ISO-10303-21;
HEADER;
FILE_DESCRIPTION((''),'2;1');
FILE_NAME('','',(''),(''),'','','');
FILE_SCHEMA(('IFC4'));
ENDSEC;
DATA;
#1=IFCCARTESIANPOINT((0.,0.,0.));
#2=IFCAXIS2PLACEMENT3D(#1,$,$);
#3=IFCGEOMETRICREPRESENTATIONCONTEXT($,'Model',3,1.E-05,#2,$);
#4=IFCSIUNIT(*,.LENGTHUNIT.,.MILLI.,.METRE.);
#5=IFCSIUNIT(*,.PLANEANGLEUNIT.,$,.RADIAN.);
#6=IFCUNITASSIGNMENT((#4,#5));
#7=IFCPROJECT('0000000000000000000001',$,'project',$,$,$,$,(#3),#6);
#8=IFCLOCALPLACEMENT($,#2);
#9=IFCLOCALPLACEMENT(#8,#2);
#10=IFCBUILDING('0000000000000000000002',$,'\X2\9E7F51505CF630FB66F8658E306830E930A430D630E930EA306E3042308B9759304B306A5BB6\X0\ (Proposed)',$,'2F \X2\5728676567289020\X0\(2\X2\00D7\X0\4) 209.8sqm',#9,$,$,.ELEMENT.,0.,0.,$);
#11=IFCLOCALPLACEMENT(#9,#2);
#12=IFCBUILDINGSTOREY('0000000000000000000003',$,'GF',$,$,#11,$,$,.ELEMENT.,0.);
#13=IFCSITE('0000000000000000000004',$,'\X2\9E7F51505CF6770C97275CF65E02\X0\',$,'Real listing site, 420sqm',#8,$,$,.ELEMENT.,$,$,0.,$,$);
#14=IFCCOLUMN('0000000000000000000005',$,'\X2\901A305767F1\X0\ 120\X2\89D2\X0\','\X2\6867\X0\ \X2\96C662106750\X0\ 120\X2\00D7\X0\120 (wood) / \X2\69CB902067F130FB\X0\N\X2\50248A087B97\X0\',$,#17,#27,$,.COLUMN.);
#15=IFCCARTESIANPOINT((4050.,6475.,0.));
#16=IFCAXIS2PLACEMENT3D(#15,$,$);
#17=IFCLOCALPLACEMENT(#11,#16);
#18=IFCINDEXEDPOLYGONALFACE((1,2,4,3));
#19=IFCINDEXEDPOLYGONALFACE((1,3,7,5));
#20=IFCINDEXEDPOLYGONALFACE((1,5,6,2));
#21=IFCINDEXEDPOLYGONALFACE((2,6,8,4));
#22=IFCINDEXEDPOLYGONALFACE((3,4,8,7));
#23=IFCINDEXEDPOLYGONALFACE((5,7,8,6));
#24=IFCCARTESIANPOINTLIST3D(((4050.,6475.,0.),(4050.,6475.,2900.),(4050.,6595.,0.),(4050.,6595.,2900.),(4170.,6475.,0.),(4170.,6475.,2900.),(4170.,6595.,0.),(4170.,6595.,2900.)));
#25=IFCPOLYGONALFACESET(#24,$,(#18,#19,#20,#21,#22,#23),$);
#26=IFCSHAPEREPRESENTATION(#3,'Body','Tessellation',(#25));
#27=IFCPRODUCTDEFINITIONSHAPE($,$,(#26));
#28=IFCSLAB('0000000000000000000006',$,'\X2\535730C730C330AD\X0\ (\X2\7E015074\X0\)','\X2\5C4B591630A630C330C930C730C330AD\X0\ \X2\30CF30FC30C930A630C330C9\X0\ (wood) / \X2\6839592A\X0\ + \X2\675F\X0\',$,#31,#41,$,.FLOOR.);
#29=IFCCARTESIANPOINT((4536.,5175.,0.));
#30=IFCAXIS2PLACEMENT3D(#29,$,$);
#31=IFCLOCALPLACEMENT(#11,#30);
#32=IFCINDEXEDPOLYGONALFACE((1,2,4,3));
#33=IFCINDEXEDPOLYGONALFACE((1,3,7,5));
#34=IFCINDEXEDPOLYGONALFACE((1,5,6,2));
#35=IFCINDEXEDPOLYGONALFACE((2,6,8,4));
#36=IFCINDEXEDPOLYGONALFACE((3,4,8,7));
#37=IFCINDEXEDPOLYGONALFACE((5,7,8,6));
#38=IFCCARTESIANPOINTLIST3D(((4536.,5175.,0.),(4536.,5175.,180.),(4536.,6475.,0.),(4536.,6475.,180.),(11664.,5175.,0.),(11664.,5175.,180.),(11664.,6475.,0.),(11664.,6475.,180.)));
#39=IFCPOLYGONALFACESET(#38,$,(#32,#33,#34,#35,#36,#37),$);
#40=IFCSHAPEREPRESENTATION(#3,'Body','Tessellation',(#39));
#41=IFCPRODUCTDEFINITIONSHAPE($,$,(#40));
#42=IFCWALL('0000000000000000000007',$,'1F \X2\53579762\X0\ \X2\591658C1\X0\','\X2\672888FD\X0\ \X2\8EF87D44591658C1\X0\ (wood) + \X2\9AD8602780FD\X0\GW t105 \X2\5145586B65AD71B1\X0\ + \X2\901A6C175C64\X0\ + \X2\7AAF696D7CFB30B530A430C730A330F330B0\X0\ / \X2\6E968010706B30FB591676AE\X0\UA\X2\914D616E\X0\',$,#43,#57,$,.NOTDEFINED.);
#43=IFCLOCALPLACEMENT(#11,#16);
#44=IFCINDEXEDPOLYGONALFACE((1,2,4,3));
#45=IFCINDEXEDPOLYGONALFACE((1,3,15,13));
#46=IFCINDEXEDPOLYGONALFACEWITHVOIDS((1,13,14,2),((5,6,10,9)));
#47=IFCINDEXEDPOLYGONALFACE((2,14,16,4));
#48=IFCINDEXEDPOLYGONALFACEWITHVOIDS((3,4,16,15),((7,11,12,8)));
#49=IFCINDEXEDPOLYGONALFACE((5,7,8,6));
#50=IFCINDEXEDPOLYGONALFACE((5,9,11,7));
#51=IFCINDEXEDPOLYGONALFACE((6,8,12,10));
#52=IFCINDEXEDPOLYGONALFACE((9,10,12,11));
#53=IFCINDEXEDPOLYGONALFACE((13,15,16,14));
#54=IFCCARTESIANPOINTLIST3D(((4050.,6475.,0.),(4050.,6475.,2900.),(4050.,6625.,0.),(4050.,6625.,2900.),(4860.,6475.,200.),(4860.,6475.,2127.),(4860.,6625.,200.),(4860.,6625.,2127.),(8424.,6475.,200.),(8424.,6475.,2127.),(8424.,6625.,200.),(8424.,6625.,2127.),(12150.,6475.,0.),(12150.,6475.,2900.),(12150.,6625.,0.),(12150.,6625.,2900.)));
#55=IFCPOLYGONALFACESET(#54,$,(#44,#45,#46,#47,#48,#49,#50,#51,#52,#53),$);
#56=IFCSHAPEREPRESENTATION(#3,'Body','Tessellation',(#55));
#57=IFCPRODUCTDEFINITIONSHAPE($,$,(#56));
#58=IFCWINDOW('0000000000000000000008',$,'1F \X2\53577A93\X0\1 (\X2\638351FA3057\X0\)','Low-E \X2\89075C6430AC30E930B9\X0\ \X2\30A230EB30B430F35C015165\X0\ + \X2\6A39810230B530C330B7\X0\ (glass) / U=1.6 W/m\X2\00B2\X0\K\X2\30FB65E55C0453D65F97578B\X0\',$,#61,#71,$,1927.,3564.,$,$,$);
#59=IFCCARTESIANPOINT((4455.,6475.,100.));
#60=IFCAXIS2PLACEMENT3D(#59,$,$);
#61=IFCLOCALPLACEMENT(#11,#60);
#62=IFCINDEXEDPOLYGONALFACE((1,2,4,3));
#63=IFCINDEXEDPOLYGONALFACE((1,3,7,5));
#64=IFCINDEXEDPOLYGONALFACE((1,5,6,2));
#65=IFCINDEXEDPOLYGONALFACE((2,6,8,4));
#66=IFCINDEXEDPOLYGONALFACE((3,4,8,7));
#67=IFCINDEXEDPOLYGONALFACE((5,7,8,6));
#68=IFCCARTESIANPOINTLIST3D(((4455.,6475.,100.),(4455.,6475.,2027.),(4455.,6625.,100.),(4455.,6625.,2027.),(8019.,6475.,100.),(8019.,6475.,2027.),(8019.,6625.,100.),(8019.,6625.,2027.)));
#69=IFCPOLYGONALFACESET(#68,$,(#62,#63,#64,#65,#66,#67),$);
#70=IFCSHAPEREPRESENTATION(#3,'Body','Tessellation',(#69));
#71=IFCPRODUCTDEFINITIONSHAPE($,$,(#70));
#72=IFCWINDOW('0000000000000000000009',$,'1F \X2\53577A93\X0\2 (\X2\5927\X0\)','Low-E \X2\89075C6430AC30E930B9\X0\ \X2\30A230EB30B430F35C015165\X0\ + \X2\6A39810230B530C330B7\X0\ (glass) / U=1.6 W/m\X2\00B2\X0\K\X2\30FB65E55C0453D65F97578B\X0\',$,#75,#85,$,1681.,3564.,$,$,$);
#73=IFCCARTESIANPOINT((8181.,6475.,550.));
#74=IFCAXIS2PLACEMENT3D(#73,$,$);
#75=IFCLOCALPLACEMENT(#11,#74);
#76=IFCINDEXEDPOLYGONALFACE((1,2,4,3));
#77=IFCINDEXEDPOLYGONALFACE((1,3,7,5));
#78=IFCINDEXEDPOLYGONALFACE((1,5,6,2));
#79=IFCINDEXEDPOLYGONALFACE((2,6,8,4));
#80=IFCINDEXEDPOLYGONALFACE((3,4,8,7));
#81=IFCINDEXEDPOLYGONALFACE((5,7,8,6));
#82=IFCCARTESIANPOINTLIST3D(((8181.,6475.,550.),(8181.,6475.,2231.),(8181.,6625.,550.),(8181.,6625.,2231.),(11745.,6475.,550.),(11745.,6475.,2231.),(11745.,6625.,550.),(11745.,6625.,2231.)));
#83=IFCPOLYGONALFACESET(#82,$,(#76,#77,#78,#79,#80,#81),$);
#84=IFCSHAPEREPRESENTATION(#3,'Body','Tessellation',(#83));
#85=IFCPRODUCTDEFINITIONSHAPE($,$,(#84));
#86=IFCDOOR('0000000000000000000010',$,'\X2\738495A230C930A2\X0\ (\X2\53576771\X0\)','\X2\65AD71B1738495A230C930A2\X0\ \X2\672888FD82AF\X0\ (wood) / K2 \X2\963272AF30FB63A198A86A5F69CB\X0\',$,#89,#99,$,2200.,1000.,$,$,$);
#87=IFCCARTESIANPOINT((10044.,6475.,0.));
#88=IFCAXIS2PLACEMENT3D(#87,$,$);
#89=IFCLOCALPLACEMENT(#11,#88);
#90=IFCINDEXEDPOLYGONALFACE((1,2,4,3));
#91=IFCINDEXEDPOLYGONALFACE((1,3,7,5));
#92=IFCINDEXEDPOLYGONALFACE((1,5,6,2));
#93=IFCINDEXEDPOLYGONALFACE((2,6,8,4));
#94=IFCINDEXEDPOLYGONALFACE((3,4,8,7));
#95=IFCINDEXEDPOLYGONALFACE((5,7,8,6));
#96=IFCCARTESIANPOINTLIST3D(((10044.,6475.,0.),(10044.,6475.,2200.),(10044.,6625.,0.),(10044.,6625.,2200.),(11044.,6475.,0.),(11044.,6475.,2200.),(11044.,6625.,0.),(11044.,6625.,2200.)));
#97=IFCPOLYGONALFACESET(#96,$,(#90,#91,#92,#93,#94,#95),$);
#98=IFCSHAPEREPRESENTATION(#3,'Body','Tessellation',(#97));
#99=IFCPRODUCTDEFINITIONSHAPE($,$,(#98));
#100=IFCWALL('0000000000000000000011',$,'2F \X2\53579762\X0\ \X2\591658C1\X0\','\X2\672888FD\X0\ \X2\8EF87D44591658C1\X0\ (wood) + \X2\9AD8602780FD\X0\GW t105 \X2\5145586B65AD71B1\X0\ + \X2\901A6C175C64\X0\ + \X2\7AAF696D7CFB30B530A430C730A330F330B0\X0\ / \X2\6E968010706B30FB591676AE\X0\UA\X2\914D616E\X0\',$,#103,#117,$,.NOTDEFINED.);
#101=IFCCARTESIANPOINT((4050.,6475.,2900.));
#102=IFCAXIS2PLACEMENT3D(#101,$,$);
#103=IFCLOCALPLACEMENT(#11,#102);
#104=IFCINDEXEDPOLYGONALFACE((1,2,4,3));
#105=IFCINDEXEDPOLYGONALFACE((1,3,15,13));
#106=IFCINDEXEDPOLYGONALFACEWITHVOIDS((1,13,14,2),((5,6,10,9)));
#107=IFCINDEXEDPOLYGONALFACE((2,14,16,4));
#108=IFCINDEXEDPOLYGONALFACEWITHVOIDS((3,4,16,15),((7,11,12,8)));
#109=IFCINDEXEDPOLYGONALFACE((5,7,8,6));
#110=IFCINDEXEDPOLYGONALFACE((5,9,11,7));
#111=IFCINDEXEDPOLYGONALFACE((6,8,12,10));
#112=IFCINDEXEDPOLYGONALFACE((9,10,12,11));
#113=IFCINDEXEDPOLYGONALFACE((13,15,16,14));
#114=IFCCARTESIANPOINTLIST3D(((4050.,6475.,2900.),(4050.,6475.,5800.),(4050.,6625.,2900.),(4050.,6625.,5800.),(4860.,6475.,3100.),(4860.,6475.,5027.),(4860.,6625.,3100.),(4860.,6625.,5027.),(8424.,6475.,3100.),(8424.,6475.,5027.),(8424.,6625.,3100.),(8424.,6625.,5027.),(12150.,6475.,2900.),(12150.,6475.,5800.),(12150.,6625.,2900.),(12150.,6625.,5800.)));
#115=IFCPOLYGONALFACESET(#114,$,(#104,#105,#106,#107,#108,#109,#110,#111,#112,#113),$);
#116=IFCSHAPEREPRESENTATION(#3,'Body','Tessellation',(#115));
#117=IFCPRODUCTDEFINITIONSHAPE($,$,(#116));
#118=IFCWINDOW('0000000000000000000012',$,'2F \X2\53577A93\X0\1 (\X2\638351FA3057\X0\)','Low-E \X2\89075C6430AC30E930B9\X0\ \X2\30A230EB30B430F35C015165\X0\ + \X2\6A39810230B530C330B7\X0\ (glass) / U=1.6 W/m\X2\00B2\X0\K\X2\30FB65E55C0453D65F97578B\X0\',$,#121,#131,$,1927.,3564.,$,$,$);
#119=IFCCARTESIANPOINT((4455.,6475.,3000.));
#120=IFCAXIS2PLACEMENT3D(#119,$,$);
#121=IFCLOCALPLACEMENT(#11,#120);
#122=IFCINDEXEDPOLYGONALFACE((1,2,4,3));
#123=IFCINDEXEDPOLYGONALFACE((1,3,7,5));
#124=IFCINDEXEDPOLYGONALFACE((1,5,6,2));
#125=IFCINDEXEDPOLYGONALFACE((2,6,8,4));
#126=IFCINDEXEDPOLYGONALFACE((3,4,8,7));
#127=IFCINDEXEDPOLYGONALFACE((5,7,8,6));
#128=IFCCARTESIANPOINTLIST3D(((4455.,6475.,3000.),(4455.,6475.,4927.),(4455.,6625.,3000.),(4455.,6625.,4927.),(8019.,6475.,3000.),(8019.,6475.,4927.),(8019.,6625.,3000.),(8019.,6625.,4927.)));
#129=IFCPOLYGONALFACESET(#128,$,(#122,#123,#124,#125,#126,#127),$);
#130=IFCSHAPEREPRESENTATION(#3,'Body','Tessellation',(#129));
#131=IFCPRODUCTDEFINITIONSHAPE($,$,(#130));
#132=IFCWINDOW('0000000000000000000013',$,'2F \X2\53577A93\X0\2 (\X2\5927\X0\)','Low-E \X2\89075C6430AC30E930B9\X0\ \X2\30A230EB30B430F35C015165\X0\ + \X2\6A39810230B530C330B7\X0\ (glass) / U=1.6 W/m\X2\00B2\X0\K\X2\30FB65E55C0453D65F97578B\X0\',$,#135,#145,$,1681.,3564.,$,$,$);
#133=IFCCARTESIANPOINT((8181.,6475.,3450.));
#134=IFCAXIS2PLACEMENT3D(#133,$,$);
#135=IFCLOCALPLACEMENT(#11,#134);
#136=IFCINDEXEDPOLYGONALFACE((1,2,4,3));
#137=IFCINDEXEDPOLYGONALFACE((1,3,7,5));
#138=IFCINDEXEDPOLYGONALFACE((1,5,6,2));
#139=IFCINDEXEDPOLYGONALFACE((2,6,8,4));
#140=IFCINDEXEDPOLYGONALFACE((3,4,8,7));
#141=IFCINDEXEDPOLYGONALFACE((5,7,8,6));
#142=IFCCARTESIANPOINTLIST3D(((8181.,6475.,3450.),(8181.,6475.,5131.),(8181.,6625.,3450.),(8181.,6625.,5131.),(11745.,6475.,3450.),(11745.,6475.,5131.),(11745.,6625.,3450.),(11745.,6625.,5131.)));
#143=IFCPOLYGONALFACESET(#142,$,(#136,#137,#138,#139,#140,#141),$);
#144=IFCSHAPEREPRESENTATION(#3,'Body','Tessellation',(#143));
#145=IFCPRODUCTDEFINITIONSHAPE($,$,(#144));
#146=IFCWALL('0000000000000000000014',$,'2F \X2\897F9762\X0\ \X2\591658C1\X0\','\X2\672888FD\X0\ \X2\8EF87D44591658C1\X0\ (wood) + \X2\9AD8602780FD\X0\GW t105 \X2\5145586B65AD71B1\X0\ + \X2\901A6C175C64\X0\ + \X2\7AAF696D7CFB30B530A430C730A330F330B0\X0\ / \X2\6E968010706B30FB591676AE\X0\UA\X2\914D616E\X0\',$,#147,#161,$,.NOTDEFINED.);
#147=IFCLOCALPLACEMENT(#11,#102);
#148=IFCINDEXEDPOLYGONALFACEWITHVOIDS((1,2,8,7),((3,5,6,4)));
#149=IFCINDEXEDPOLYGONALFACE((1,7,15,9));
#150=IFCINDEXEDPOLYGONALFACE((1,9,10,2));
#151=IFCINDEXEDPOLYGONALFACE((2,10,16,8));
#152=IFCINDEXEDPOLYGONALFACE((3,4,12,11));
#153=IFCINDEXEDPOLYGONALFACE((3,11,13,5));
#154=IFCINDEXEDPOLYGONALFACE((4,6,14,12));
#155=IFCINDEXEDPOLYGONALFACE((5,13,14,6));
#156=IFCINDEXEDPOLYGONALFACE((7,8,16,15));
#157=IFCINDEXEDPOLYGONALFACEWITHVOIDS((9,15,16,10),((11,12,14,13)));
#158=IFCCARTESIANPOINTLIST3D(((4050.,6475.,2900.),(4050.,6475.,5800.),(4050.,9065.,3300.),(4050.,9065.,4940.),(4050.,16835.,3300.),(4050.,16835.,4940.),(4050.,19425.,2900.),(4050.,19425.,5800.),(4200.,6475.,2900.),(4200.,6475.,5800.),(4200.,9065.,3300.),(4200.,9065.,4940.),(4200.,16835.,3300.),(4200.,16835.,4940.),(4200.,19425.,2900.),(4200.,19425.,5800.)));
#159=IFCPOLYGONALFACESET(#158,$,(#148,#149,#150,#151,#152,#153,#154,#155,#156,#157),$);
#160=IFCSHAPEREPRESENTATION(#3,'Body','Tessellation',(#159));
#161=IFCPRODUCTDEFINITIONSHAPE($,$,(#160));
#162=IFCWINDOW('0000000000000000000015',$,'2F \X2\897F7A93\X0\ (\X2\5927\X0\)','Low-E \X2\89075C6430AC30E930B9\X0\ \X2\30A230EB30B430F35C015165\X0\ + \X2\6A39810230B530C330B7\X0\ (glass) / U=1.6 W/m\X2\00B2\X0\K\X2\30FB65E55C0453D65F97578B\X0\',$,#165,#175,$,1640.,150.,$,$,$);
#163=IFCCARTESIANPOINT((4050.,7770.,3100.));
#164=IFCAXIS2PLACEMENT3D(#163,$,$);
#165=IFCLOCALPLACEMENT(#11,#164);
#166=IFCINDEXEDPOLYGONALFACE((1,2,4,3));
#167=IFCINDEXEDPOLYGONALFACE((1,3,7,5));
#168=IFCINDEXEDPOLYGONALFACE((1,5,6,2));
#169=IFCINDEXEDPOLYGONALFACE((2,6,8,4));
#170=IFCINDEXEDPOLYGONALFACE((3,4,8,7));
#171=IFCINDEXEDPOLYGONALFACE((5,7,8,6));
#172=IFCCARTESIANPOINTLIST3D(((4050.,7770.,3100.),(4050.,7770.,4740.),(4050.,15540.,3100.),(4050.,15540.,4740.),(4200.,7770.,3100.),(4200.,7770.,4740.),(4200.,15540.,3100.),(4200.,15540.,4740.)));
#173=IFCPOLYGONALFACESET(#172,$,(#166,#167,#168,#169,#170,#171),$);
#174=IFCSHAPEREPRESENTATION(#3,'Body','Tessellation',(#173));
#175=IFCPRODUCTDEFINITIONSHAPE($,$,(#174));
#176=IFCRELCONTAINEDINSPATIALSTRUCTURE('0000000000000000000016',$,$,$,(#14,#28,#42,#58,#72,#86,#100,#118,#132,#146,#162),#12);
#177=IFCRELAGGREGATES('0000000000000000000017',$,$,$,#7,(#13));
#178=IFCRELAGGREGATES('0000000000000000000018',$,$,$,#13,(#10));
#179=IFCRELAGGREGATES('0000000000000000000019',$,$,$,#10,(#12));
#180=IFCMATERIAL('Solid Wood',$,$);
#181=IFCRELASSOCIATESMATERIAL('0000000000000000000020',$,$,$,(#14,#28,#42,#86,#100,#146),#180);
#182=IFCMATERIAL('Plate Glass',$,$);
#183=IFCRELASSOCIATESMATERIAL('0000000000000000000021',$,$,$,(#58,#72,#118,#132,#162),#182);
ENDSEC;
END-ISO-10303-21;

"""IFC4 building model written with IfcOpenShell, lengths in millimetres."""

from ifc_helpers import new_model, si_unit, frame, frame_2d, origin, place, context, project, spatial, rectangle, extrude, material, element, fill, save


model = new_model("IFC4")

# Units and contexts
model_context = context("Model", 3, precision=1e-05, world=origin())
ifc_project = project(units=[si_unit("LENGTHUNIT", "METRE", prefix="MILLI"), si_unit("PLANEANGLEUNIT", "RADIAN")], contexts=[model_context])

# Site, building, storey
site_placement = place(None, origin())
site = spatial("IfcSite", under=ifc_project, at=site_placement, Name="鹿児島県霧島市", ObjectType="Real listing site, 420sqm", CompositionType="ELEMENT", RefElevation=0.0)
building_placement = place(site_placement, origin())
building = spatial("IfcBuilding", under=site, at=building_placement, Name="鹿児島・書斎とライブラリのある静かな家 (Proposed)", ObjectType="2F 在来木造(2×4) 209.8sqm", CompositionType="ELEMENT", ElevationOfRefHeight=0.0, ElevationOfTerrain=0.0)
storey_placement = place(building_placement, origin())
storey = spatial("IfcBuildingStorey", under=building, at=storey_placement, Name="GF", CompositionType="ELEMENT", Elevation=0.0)

# Column
ifc_material_1 = material(Name="Solid Wood")
column_placement = place(storey_placement, frame((4050.0, 6475.0, 0.0)))
element("IfcColumn", 1, at=column_placement, inside=storey, material=ifc_material_1, Name="通し柱 120角", Description="桧 集成材 120×120 (wood) / 構造柱・N値計算", PredefinedType="COLUMN", context=model_context, shape_type="SweptSolid", body=[
    extrude(rectangle(XDim=120.0, YDim=120.0, at=frame_2d((60.0, 60.0))), frame((4050.0, 6475.0, 0.0)), (0.0, 0.0, 1.0), 2900.0),
])

# Slab
slab_1_placement = place(storey_placement, frame((4536.0, 5175.0, 0.0)))
element("IfcSlab", 2, at=slab_1_placement, inside=storey, material=ifc_material_1, Name="南デッキ (縁側)", Description="屋外ウッドデッキ ハードウッド (wood) / 根太 + 束", PredefinedType="FLOOR", context=model_context, shape_type="SweptSolid", body=[
    extrude(rectangle(XDim=7128.0, YDim=1300.0, at=frame_2d((3564.0, 650.0))), frame((4536.0, 5175.0, 0.0)), (0.0, 0.0, 1.0), 180.0),
])

# Wall, openings, windows, door
wall_1_placement = place(storey_placement, frame((4050.0, 6475.0, 0.0)))
wall_1 = element("IfcWall", 3, at=wall_1_placement, inside=storey, material=ifc_material_1, Name="1F 南面 外壁", Description="木製 軸組外壁 (wood) + 高性能GW t105 充填断熱 + 通気層 + 窯業系サイディング / 準耐火・外皮UA配慮", PredefinedType="NOTDEFINED", context=model_context, shape_type="SweptSolid", body=[
    extrude(rectangle(XDim=8100.0, YDim=150.0, at=frame_2d((4050.0, 75.0))), frame((4050.0, 6475.0, 0.0)), (0.0, 0.0, 1.0), 2900.0),
])
opening_1_placement = place(storey_placement, frame((4455.0, 6475.0, 100.0)))
opening_1 = element("IfcOpeningElement", 4, at=opening_1_placement, cuts=wall_1, PredefinedType="NOTDEFINED", context=model_context, shape_type="SweptSolid", body=[
    extrude(rectangle(XDim=3564.0, YDim=150.0, at=frame_2d((1782.0, 75.0))), frame((4455.0, 6475.0, 100.0)), (0.0, 0.0, 1.0), 1927.0),
])
opening_2_placement = place(storey_placement, frame((8181.0, 6475.0, 550.0)))
opening_2 = element("IfcOpeningElement", 5, at=opening_2_placement, cuts=wall_1, PredefinedType="NOTDEFINED", context=model_context, shape_type="SweptSolid", body=[
    extrude(rectangle(XDim=3564.0, YDim=150.0, at=frame_2d((1782.0, 75.0))), frame((8181.0, 6475.0, 550.0)), (0.0, 0.0, 1.0), 1681.0),
])
opening_3_placement = place(storey_placement, frame((10044.0, 6475.0, 0.0)))
opening_3 = element("IfcOpeningElement", 6, at=opening_3_placement, cuts=wall_1, PredefinedType="NOTDEFINED", context=model_context, shape_type="SweptSolid", body=[
    extrude(rectangle(XDim=1000.0, YDim=150.0, at=frame_2d((500.0, 75.0))), frame((10044.0, 6475.0, 0.0)), (0.0, 0.0, 1.0), 2200.0),
])
ifc_material_2 = material(Name="Plate Glass")
window_1_placement = place(storey_placement, frame((4455.0, 6475.0, 100.0)))
window_1 = element("IfcWindow", 7, at=window_1_placement, inside=storey, material=ifc_material_2, Name="1F 南窓1 (掃出し)", Description="Low-E 複層ガラス アルゴン封入 + 樹脂サッシ (glass) / U=1.6 W/m²K・日射取得型", OverallHeight=1927.0, OverallWidth=3564.0, context=model_context, shape_type="SweptSolid", body=[
    extrude(rectangle(XDim=3564.0, YDim=150.0, at=frame_2d((1782.0, 75.0))), frame((4455.0, 6475.0, 100.0)), (0.0, 0.0, 1.0), 1927.0),
])
fill(opening_1, window_1)
window_2_placement = place(storey_placement, frame((8181.0, 6475.0, 550.0)))
window_2 = element("IfcWindow", 8, at=window_2_placement, inside=storey, material=ifc_material_2, Name="1F 南窓2 (大)", Description="Low-E 複層ガラス アルゴン封入 + 樹脂サッシ (glass) / U=1.6 W/m²K・日射取得型", OverallHeight=1681.0, OverallWidth=3564.0, context=model_context, shape_type="SweptSolid", body=[
    extrude(rectangle(XDim=3564.0, YDim=150.0, at=frame_2d((1782.0, 75.0))), frame((8181.0, 6475.0, 550.0)), (0.0, 0.0, 1.0), 1681.0),
])
fill(opening_2, window_2)
door_placement = place(storey_placement, frame((10044.0, 6475.0, 0.0)))
door = element("IfcDoor", 9, at=door_placement, inside=storey, material=ifc_material_1, Name="玄関ドア (南東)", Description="断熱玄関ドア 木製芯 (wood) / K2 防犯・採風機構", OverallHeight=2200.0, OverallWidth=1000.0, context=model_context, shape_type="SweptSolid", body=[
    extrude(rectangle(XDim=1000.0, YDim=150.0, at=frame_2d((500.0, 75.0))), frame((10044.0, 6475.0, 0.0)), (0.0, 0.0, 1.0), 2200.0),
])
fill(opening_3, door)

# Wall, openings, windows
wall_2_placement = place(storey_placement, frame((4050.0, 6475.0, 2900.0)))
wall_2 = element("IfcWall", 10, at=wall_2_placement, inside=storey, material=ifc_material_1, Name="2F 南面 外壁", Description="木製 軸組外壁 (wood) + 高性能GW t105 充填断熱 + 通気層 + 窯業系サイディング / 準耐火・外皮UA配慮", PredefinedType="NOTDEFINED", context=model_context, shape_type="SweptSolid", body=[
    extrude(rectangle(XDim=8100.0, YDim=150.0, at=frame_2d((4050.0, 75.0))), frame((4050.0, 6475.0, 2900.0)), (0.0, 0.0, 1.0), 2900.0),
])
opening_4_placement = place(storey_placement, frame((4455.0, 6475.0, 3000.0)))
opening_4 = element("IfcOpeningElement", 11, at=opening_4_placement, cuts=wall_2, PredefinedType="NOTDEFINED", context=model_context, shape_type="SweptSolid", body=[
    extrude(rectangle(XDim=3564.0, YDim=150.0, at=frame_2d((1782.0, 75.0))), frame((4455.0, 6475.0, 3000.0)), (0.0, 0.0, 1.0), 1927.0),
])
opening_5_placement = place(storey_placement, frame((8181.0, 6475.0, 3450.0)))
opening_5 = element("IfcOpeningElement", 12, at=opening_5_placement, cuts=wall_2, PredefinedType="NOTDEFINED", context=model_context, shape_type="SweptSolid", body=[
    extrude(rectangle(XDim=3564.0, YDim=150.0, at=frame_2d((1782.0, 75.0))), frame((8181.0, 6475.0, 3450.0)), (0.0, 0.0, 1.0), 1681.0),
])
window_3_placement = place(storey_placement, frame((4455.0, 6475.0, 3000.0)))
window_3 = element("IfcWindow", 13, at=window_3_placement, inside=storey, material=ifc_material_2, Name="2F 南窓1 (掃出し)", Description="Low-E 複層ガラス アルゴン封入 + 樹脂サッシ (glass) / U=1.6 W/m²K・日射取得型", OverallHeight=1927.0, OverallWidth=3564.0, context=model_context, shape_type="SweptSolid", body=[
    extrude(rectangle(XDim=3564.0, YDim=150.0, at=frame_2d((1782.0, 75.0))), frame((4455.0, 6475.0, 3000.0)), (0.0, 0.0, 1.0), 1927.0),
])
fill(opening_4, window_3)
window_4_placement = place(storey_placement, frame((8181.0, 6475.0, 3450.0)))
window_4 = element("IfcWindow", 14, at=window_4_placement, inside=storey, material=ifc_material_2, Name="2F 南窓2 (大)", Description="Low-E 複層ガラス アルゴン封入 + 樹脂サッシ (glass) / U=1.6 W/m²K・日射取得型", OverallHeight=1681.0, OverallWidth=3564.0, context=model_context, shape_type="SweptSolid", body=[
    extrude(rectangle(XDim=3564.0, YDim=150.0, at=frame_2d((1782.0, 75.0))), frame((8181.0, 6475.0, 3450.0)), (0.0, 0.0, 1.0), 1681.0),
])
fill(opening_5, window_4)

# Wall, opening, window
wall_3_placement = place(storey_placement, frame((4050.0, 6475.0, 2900.0)))
wall_3 = element("IfcWall", 15, at=wall_3_placement, inside=storey, material=ifc_material_1, Name="2F 西面 外壁", Description="木製 軸組外壁 (wood) + 高性能GW t105 充填断熱 + 通気層 + 窯業系サイディング / 準耐火・外皮UA配慮", PredefinedType="NOTDEFINED", context=model_context, shape_type="SweptSolid", body=[
    extrude(rectangle(XDim=150.0, YDim=12950.0, at=frame_2d((75.0, 6475.0))), frame((4050.0, 6475.0, 2900.0)), (0.0, 0.0, 1.0), 2900.0),
])
opening_6_placement = place(storey_placement, frame((4050.0, 7770.0, 3100.0)))
opening_6 = element("IfcOpeningElement", 16, at=opening_6_placement, cuts=wall_3, PredefinedType="NOTDEFINED", context=model_context, shape_type="SweptSolid", body=[
    extrude(rectangle(XDim=150.0, YDim=7770.0, at=frame_2d((75.0, 3885.0))), frame((4050.0, 7770.0, 3100.0)), (0.0, 0.0, 1.0), 1640.0),
])
window_5_placement = place(storey_placement, frame((4050.0, 7770.0, 3100.0)))
window_5 = element("IfcWindow", 17, at=window_5_placement, inside=storey, material=ifc_material_2, Name="2F 西窓 (大)", Description="Low-E 複層ガラス アルゴン封入 + 樹脂サッシ (glass) / U=1.6 W/m²K・日射取得型", OverallHeight=1640.0, OverallWidth=150.0, context=model_context, shape_type="SweptSolid", body=[
    extrude(rectangle(XDim=150.0, YDim=7770.0, at=frame_2d((75.0, 3885.0))), frame((4050.0, 7770.0, 3100.0)), (0.0, 0.0, 1.0), 1640.0),
])
fill(opening_6, window_5)

save(model, "model.ifc")
